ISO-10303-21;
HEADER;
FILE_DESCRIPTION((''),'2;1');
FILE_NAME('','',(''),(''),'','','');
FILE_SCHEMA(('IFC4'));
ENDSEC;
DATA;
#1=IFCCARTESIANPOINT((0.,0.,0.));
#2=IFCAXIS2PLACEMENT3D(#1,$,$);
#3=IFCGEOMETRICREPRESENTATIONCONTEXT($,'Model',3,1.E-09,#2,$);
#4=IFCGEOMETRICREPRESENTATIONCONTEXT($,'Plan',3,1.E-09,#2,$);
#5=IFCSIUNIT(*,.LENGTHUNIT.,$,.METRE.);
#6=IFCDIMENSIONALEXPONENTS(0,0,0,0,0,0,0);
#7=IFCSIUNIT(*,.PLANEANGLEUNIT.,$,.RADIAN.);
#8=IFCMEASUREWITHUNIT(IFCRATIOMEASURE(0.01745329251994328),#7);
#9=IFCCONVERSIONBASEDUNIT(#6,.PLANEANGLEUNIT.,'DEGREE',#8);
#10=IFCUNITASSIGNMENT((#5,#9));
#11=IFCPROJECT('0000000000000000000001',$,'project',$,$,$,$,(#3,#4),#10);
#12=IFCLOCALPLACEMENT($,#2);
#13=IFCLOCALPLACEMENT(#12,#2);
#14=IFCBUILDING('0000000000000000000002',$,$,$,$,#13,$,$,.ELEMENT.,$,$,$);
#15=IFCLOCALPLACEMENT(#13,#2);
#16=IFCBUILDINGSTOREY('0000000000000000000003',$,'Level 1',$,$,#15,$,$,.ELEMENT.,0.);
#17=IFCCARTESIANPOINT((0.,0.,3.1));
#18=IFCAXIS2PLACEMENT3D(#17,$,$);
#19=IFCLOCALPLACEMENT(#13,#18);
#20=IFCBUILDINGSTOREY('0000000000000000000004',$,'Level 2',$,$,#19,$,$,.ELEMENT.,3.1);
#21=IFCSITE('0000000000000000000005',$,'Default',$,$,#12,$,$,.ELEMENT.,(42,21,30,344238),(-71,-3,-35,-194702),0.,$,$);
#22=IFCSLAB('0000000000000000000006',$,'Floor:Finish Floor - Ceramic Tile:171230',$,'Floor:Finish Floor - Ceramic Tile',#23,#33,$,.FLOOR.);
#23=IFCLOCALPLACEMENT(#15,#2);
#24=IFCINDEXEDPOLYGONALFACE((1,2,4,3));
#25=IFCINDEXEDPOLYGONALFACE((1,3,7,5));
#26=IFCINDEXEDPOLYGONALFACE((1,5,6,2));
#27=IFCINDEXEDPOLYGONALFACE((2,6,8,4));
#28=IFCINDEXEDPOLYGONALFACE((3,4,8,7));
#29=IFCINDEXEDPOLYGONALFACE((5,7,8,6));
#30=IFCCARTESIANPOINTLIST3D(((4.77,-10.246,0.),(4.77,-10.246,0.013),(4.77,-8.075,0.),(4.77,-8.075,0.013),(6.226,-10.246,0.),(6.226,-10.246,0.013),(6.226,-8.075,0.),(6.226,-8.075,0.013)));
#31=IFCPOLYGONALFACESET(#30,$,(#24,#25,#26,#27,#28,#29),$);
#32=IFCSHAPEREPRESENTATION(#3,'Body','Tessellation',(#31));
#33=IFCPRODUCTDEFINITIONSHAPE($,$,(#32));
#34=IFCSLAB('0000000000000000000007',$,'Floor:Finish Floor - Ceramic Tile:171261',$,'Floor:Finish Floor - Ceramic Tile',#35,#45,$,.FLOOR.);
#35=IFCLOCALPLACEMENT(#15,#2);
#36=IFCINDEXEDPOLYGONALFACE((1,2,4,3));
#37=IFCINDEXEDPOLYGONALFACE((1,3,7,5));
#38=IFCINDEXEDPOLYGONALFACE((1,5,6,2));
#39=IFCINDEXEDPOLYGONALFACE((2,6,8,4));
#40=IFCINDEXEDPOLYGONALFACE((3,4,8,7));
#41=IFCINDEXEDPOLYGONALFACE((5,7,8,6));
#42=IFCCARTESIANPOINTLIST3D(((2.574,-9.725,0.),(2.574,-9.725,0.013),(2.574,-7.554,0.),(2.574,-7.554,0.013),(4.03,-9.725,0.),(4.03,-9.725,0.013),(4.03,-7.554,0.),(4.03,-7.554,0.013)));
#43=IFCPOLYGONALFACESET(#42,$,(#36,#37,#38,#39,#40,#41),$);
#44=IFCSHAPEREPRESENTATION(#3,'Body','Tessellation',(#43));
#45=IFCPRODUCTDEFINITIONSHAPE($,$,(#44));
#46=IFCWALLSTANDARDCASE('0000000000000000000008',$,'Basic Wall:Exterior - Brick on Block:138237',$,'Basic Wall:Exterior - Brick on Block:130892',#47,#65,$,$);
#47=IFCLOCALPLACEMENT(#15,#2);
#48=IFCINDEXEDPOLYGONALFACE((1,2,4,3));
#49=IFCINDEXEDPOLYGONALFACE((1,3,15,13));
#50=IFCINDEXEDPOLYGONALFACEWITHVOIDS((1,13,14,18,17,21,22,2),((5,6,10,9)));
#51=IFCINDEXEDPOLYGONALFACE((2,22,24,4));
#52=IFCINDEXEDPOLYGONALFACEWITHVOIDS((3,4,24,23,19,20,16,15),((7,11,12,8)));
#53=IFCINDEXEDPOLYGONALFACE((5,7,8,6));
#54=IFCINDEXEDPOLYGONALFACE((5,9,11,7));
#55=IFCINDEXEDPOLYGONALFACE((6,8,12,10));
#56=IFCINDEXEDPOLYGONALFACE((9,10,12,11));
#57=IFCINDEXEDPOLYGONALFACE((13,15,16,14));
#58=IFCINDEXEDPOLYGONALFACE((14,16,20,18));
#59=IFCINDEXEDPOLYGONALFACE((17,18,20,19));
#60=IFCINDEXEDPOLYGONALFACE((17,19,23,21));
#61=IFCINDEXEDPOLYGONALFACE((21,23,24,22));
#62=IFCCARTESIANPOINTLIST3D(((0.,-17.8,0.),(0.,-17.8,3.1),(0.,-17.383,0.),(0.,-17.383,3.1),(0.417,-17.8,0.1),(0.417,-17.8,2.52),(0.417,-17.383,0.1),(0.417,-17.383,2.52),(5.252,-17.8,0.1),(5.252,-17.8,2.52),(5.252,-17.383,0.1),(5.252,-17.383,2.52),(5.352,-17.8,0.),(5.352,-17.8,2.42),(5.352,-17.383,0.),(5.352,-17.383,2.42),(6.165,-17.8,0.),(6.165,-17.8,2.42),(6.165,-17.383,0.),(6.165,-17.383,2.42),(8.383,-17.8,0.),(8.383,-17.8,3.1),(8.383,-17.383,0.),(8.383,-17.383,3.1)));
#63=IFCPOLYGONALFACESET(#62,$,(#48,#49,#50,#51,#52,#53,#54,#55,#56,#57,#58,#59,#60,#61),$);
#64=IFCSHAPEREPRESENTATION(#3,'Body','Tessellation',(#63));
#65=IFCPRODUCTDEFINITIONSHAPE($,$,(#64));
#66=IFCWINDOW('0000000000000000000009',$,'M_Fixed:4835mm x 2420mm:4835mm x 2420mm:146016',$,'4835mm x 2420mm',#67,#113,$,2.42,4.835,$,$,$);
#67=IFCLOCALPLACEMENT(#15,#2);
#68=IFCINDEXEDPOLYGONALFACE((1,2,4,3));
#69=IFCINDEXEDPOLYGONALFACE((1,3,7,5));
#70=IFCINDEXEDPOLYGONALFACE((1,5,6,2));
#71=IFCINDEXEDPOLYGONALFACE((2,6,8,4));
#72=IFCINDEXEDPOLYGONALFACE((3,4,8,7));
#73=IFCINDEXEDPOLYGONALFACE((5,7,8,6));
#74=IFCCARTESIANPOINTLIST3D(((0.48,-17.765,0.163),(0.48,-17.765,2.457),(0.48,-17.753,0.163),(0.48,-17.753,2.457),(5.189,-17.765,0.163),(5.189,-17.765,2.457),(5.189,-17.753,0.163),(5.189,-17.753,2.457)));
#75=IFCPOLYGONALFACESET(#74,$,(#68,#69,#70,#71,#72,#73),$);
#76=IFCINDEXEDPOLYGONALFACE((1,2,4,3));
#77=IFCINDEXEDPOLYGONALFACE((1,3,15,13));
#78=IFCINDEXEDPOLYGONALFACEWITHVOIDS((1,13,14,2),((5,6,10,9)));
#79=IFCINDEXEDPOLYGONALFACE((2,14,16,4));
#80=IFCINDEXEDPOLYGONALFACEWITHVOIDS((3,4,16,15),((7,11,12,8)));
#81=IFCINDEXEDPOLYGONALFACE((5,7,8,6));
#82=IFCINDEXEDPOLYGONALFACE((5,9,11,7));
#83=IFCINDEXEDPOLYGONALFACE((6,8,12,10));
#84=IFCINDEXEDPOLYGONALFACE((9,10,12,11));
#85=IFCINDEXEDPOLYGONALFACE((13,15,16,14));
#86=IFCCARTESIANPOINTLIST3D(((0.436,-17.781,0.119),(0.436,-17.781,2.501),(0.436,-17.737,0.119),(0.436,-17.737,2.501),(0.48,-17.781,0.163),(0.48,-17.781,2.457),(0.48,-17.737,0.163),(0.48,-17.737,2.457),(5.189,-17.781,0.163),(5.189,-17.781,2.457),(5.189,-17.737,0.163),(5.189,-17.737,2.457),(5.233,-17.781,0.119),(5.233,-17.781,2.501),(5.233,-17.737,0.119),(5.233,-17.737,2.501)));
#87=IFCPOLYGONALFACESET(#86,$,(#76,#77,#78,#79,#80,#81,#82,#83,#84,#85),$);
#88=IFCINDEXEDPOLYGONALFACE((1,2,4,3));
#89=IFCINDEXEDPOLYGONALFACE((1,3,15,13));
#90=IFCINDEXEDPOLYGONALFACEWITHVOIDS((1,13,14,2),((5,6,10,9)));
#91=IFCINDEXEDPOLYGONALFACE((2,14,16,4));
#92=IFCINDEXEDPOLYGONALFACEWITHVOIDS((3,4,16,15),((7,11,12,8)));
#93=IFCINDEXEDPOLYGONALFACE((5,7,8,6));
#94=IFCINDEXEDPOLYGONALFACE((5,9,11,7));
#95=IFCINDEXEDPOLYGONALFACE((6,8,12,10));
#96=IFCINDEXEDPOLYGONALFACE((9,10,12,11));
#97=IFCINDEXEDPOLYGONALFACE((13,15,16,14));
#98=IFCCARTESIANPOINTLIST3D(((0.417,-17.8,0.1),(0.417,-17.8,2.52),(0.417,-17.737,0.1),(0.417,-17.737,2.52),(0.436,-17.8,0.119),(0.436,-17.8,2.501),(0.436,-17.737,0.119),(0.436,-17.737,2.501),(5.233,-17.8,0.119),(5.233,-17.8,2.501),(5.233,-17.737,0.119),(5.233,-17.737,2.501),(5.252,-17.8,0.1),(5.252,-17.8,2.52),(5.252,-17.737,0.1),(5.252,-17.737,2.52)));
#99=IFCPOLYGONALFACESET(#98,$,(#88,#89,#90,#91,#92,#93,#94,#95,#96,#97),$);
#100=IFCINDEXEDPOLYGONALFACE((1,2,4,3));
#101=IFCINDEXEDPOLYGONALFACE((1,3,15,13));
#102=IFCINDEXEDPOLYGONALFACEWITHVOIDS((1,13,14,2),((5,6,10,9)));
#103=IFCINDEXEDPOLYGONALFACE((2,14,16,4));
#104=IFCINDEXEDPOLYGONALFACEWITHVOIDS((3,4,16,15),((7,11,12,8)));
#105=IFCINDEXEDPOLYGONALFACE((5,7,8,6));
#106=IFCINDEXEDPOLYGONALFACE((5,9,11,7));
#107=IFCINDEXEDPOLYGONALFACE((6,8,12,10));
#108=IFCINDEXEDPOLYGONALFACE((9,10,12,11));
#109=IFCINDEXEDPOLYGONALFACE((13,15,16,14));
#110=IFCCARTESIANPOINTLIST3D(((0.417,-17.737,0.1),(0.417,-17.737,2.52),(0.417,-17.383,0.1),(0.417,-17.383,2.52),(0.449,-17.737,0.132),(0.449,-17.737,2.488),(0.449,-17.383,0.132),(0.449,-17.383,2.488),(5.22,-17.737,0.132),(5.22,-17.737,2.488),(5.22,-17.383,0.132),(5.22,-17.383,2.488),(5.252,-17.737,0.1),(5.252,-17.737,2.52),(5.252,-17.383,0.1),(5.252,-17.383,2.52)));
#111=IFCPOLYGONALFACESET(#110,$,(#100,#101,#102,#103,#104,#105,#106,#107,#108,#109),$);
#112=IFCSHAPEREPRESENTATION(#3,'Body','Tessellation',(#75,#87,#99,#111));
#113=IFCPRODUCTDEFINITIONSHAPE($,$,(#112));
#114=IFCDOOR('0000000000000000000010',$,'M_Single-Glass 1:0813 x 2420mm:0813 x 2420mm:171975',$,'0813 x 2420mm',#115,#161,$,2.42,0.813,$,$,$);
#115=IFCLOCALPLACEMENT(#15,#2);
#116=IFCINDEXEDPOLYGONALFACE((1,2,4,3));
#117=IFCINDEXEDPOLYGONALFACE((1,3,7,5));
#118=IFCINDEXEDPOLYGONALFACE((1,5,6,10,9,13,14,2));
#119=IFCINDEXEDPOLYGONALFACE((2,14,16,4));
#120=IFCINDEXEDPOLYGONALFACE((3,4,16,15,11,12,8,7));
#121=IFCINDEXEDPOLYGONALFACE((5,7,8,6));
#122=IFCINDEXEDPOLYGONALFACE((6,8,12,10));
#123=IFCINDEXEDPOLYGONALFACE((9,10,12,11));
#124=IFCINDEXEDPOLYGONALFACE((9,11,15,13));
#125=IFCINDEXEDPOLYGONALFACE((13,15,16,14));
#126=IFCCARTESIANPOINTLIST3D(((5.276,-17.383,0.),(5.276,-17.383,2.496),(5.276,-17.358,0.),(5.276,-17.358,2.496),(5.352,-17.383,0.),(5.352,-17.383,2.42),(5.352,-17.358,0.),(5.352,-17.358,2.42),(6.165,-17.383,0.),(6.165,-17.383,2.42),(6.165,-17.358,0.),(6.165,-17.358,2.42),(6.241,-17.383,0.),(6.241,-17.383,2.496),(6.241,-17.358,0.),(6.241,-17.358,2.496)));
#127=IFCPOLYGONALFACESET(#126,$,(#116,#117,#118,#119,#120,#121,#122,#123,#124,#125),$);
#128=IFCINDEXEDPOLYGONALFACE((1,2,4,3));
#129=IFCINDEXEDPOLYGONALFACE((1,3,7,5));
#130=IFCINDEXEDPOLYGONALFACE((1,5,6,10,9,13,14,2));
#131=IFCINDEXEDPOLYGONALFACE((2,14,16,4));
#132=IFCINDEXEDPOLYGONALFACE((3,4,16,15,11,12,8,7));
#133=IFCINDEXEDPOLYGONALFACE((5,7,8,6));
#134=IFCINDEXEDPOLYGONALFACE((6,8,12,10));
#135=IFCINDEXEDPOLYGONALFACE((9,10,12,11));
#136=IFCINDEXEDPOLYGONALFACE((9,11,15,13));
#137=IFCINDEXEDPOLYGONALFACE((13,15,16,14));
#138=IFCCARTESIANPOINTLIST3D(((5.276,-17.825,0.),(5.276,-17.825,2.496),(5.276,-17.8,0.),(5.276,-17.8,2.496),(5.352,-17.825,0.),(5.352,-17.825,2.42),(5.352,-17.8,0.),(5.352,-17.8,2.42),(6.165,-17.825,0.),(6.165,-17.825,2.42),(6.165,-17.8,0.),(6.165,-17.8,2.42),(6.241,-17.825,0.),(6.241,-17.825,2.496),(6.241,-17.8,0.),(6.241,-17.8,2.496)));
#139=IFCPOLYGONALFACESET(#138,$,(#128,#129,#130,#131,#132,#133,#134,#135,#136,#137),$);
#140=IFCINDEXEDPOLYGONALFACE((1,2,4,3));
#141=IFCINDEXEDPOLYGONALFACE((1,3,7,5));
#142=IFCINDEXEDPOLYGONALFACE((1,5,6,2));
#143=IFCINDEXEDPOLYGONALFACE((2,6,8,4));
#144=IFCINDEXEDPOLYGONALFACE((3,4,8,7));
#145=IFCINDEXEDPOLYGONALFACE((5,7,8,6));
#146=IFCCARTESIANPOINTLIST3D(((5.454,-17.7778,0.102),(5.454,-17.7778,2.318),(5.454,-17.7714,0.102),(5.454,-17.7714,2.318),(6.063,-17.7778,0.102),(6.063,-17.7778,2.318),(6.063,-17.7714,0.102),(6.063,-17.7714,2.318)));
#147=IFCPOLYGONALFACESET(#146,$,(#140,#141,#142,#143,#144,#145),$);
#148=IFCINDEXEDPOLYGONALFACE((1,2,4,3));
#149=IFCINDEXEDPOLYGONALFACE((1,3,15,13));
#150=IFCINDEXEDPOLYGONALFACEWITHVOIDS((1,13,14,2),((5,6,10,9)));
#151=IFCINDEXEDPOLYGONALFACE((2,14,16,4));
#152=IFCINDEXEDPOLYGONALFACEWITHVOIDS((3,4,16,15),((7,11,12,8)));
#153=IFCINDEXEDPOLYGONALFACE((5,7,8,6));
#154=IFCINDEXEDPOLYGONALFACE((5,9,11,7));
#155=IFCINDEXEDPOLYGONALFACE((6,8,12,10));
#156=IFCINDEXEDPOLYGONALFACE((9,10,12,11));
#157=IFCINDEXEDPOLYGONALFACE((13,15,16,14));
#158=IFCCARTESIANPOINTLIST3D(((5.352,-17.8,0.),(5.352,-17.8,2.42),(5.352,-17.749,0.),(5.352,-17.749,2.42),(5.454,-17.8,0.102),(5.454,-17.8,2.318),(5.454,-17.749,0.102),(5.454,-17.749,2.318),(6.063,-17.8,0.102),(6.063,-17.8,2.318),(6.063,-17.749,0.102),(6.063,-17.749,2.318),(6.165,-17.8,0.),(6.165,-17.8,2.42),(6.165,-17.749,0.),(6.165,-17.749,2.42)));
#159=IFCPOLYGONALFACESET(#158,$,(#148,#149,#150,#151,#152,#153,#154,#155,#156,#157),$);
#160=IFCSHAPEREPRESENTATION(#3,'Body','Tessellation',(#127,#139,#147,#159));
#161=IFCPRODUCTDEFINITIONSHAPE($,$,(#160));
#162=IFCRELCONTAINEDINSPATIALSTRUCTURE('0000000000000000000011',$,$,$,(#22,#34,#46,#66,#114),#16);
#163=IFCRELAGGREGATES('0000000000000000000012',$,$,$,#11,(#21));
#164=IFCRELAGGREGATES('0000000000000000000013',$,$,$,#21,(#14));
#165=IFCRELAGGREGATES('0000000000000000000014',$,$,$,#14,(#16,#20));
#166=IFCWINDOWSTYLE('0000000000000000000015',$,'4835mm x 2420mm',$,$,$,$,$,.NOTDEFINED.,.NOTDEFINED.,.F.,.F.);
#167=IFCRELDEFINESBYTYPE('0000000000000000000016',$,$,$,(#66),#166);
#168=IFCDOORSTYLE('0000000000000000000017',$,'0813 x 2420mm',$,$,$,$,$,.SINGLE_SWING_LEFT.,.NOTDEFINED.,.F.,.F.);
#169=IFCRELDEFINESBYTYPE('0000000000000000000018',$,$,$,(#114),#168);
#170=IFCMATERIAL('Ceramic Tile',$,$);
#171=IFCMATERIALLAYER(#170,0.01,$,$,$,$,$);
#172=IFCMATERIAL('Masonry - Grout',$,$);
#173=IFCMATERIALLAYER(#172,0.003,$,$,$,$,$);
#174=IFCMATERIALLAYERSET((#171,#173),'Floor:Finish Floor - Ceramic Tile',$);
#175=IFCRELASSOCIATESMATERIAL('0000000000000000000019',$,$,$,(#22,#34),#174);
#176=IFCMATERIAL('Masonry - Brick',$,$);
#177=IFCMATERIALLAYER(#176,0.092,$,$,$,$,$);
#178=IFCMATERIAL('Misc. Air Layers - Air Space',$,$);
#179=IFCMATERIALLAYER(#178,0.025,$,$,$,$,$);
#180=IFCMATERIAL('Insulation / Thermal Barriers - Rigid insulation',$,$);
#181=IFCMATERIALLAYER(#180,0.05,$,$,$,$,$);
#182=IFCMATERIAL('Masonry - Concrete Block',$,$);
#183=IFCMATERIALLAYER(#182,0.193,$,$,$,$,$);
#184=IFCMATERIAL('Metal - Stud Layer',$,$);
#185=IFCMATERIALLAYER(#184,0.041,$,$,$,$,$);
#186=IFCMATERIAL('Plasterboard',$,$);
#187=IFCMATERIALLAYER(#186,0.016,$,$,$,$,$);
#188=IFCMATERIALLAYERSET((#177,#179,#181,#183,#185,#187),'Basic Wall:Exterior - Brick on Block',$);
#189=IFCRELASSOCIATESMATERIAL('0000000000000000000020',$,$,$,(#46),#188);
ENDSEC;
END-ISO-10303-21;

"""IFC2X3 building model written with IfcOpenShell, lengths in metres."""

from ifc_helpers import new_model, entity, si_unit, converted_unit, frame, frame_2d, origin, origin_2d_with_axis, place, context, project, spatial, polyline, rectangle, outline, extrude, source, transform, mapped, material, layer, layer_set, layer_usage, type_object, type_shapes, element, fill, save


model = new_model("IFC2X3")

# Units and contexts
model_context = context("Model", 3, precision=1e-09, world=origin())
plan_context = context("Plan", 3, precision=1e-09, world=origin())
ifc_project = project(units=[si_unit("LENGTHUNIT", "METRE"), converted_unit("PLANEANGLEUNIT", "DEGREE", entity("IfcRatioMeasure", 0.01745329251994328), si_unit("PLANEANGLEUNIT", "RADIAN"), dimensions=[0, 0, 0, 0, 0, 0, 0])], contexts=[model_context, plan_context])

# Site, building, storey
site_placement = place(None, origin())
site = spatial("IfcSite", under=ifc_project, at=site_placement, Name="Default", CompositionType="ELEMENT", RefLatitude=(42, 21, 30, 344238), RefLongitude=(-71, -3, -35, -194702), RefElevation=0.0)
building_placement = place(site_placement, origin())
building = spatial("IfcBuilding", under=site, at=building_placement, CompositionType="ELEMENT")
storey_1_placement = place(building_placement, origin())
storey_1 = spatial("IfcBuildingStorey", under=building, at=storey_1_placement, Name="Level 1", CompositionType="ELEMENT", Elevation=0.0)

# Slabs
ifc_material_1 = material(Name="Ceramic Tile")
ifc_layer_1 = layer(ifc_material_1, 0.01)
ifc_material_2 = material(Name="Masonry - Grout")
ifc_layer_2 = layer(ifc_material_2, 0.003)
ifc_layer_set_1 = layer_set([ifc_layer_1, ifc_layer_2], Name="Floor:Finish Floor - Ceramic Tile")
ifc_layer_usage_1 = layer_usage(ifc_layer_set_1, "AXIS3", "POSITIVE", 0.0)
slab_1_placement = place(storey_1_placement, frame((4.77, -10.246, 0.0)))
element("IfcSlab", 1, at=slab_1_placement, inside=storey_1, material=ifc_layer_usage_1, Name="Floor:Finish Floor - Ceramic Tile:171230", ObjectType="Floor:Finish Floor - Ceramic Tile", PredefinedType="FLOOR", context=model_context, shape_type="SweptSolid", body=[
    extrude(rectangle(XDim=1.456, YDim=2.171, at=frame_2d((0.0, 0.0), x_axis=(-1.0, 0.0))), frame((0.728, 1.0855, 0.013), z_axis=(0.0, 0.0, -1.0), x_axis=(-1.0, 0.0, 0.0)), (0.0, 0.0, 1.0), 0.013),
])
ifc_layer_usage_2 = layer_usage(ifc_layer_set_1, "AXIS3", "POSITIVE", 0.0)
slab_2_placement = place(storey_1_placement, frame((2.574, -9.725, 0.0)))
element("IfcSlab", 2, at=slab_2_placement, inside=storey_1, material=ifc_layer_usage_2, Name="Floor:Finish Floor - Ceramic Tile:171261", ObjectType="Floor:Finish Floor - Ceramic Tile", PredefinedType="FLOOR", context=model_context, shape_type="SweptSolid", body=[
    extrude(rectangle(XDim=2.171, YDim=1.456, at=frame_2d((0.0, 0.0), x_axis=(0.0, -1.0))), frame((0.728, 1.0855, 0.013), z_axis=(0.0, 0.0, -1.0), x_axis=(-1.0, 0.0, 0.0)), (0.0, 0.0, 1.0), 0.013),
])

# Wall, openings, window, door
ifc_material_3 = material(Name="Masonry - Brick")
ifc_layer_3 = layer(ifc_material_3, 0.092)
ifc_material_4 = material(Name="Misc. Air Layers - Air Space")
ifc_layer_4 = layer(ifc_material_4, 0.025)
ifc_material_5 = material(Name="Insulation / Thermal Barriers - Rigid insulation")
ifc_layer_5 = layer(ifc_material_5, 0.05)
ifc_material_6 = material(Name="Masonry - Concrete Block")
ifc_layer_6 = layer(ifc_material_6, 0.193)
ifc_material_7 = material(Name="Metal - Stud Layer")
ifc_layer_7 = layer(ifc_material_7, 0.041)
ifc_material_8 = material(Name="Plasterboard")
ifc_layer_8 = layer(ifc_material_8, 0.016)
ifc_layer_set_2 = layer_set([ifc_layer_3, ifc_layer_4, ifc_layer_5, ifc_layer_6, ifc_layer_7, ifc_layer_8], Name="Basic Wall:Exterior - Brick on Block")
ifc_layer_usage_3 = layer_usage(ifc_layer_set_2, "AXIS2", "NEGATIVE", 0.2085)
wall_1_placement = place(storey_1_placement, frame((8.383, -17.5915, 0.0), z_axis=(0.0, 0.0, 1.0), x_axis=(-1.0, 0.0, 0.0)))
wall_1 = element("IfcWallStandardCase", 3, at=wall_1_placement, inside=storey_1, material=ifc_layer_usage_3, Name="Basic Wall:Exterior - Brick on Block:138237", ObjectType="Basic Wall:Exterior - Brick on Block:130892", context=model_context, shape_type="SweptSolid", body=[
    extrude(rectangle(XDim=8.383, YDim=0.417, at=frame_2d((4.1915, 0.0), x_axis=(-1.0, 0.0))), origin(), (0.0, 0.0, 1.0), 3.1),
])
opening_1_placement = place(wall_1_placement, frame((3.131, -0.2085, 0.1)))
opening_1 = element("IfcOpeningElement", 4, at=opening_1_placement, cuts=wall_1, ObjectType="Opening", context=model_context, shape_type="SweptSolid", body=[
    extrude(rectangle(XDim=2.42, YDim=4.835, at=frame_2d((1.21, 2.4175), x_axis=(1.0, 0.0))), frame((0.0, 0.0, 0.0), z_axis=(0.0, 1.0, 0.0), x_axis=(0.0, 0.0, 1.0)), (0.0, 0.0, 1.0), 0.417),
])
opening_2_placement = place(wall_1_placement, frame((2.218, -0.2085, 0.0)))
opening_2 = element("IfcOpeningElement", 5, at=opening_2_placement, cuts=wall_1, ObjectType="Opening", context=model_context, shape_type="SweptSolid", body=[
    extrude(rectangle(XDim=0.813, YDim=2.42, at=frame_2d((1.21, 0.4065), x_axis=(0.0, -1.0))), frame((0.0, 0.0, 0.0), z_axis=(0.0, 1.0, 0.0), x_axis=(0.0, 0.0, 1.0)), (0.0, 0.0, 1.0), 0.417),
])
window_style_1 = type_object("IfcWindowStyle", Name="4835mm x 2420mm", ConstructionType="NOTDEFINED", OperationType="NOTDEFINED", ParameterTakesPrecedence=False, Sizeable=False)
shared_shape_1 = source(origin(), model_context, "Body", "SweptSolid", [
    extrude(rectangle(XDim=0.012, YDim=4.709, at=origin_2d_with_axis()), frame((2.4175, 0.376, 0.063), z_axis=(0.0, 0.0, 1.0), x_axis=(0.0, -1.0, 0.0)), (0.0, 0.0, 1.0), 2.294),
    extrude(outline(polyline([(-2.3985, -1.191), (2.3985, -1.191), (2.3985, 1.191), (-2.3985, 1.191), (-2.3985, -1.191)]), holes=[polyline([(-2.3545, -1.147), (-2.3545, 1.147), (2.3545, 1.147), (2.3545, -1.147), (-2.3545, -1.147)])]), frame((2.4175, 0.354, 1.21), z_axis=(0.0, 1.0, 0.0), x_axis=(1.0, 0.0, 0.0)), (0.0, 0.0, 1.0), 0.044),
    extrude(outline(polyline([(-2.4175, -1.21), (2.4175, -1.21), (2.4175, 1.21), (-2.4175, 1.21), (-2.4175, -1.21)]), holes=[polyline([(-2.3985, -1.191), (-2.3985, 1.191), (2.3985, 1.191), (2.3985, -1.191), (-2.3985, -1.191)])]), frame((2.4175, 0.354, 1.21), z_axis=(0.0, 1.0, 0.0), x_axis=(1.0, 0.0, 0.0)), (0.0, 0.0, 1.0), 0.063),
    extrude(outline(polyline([(-2.4175, -1.21), (2.4175, -1.21), (2.4175, 1.21), (-2.4175, 1.21), (-2.4175, -1.21)]), holes=[polyline([(-2.3855, -1.178), (-2.3855, 1.178), (2.3855, 1.178), (2.3855, -1.178), (-2.3855, -1.178)])]), frame((2.4175, 0.0, 1.21), z_axis=(0.0, 1.0, 0.0), x_axis=(1.0, 0.0, 0.0)), (0.0, 0.0, 1.0), 0.354),
])
type_shapes(window_style_1, [shared_shape_1])
window_1_placement = place(opening_1_placement, origin())
window_1 = element("IfcWindow", 6, at=window_1_placement, inside=storey_1, type_object=window_style_1, Name="M_Fixed:4835mm x 2420mm:4835mm x 2420mm:146016", ObjectType="4835mm x 2420mm", OverallHeight=2.42, OverallWidth=4.835, context=model_context, shape_type="MappedRepresentation", body=[
    mapped(shared_shape_1, transform((0.0, 0.0, 0.0), scale=1.0)),
])
fill(opening_1, window_1)
door_style_1 = type_object("IfcDoorStyle", Name="0813 x 2420mm", ConstructionType="NOTDEFINED", OperationType="SINGLE_SWING_LEFT", ParameterTakesPrecedence=False, Sizeable=False)
shared_shape_2 = source(origin(), model_context, "Body", "SweptSolid", [
    extrude(outline(polyline([(-0.4065, -1.191), (-0.4065, 1.229), (-0.4825, 1.229), (-0.4825, -1.267), (0.4825, -1.267), (0.4825, 1.229), (0.4065, 1.229), (0.4065, -1.191), (-0.4065, -1.191)])), frame((0.4065, 0.0, 1.229), z_axis=(0.0, 1.0, 0.0), x_axis=(1.0, 0.0, 0.0)), (0.0, 0.0, -1.0), 0.025),
    extrude(outline(polyline([(-0.4065, -1.191), (-0.4065, 1.229), (-0.4825, 1.229), (-0.4825, -1.267), (0.4825, -1.267), (0.4825, 1.229), (0.4065, 1.229), (0.4065, -1.191), (-0.4065, -1.191)])), frame((0.4065, 0.442, 1.229), z_axis=(0.0, 1.0, 0.0), x_axis=(1.0, 0.0, 0.0)), (0.0, 0.0, -1.0), 0.025),
    extrude(rectangle(XDim=0.609, YDim=0.0064, at=origin_2d_with_axis()), frame((0.4065, 0.3916, 0.102)), (0.0, 0.0, 1.0), 2.216),
    extrude(outline(polyline([(-1.21, -0.4065), (1.21, -0.4065), (1.21, 0.4065), (-1.21, 0.4065), (-1.21, -0.4065)]), holes=[polyline([(-1.108, 0.3045), (1.108, 0.3045), (1.108, -0.3045), (-1.108, -0.3045), (-1.108, 0.3045)])]), frame((0.4065, 0.417, 1.21), z_axis=(0.0, -1.0, 0.0), x_axis=(0.0, 0.0, -1.0)), (0.0, 0.0, 1.0), 0.051),
])
type_shapes(door_style_1, [shared_shape_2])
door_1_placement = place(opening_2_placement, origin())
door_1 = element("IfcDoor", 7, at=door_1_placement, inside=storey_1, type_object=door_style_1, Name="M_Single-Glass 1:0813 x 2420mm:0813 x 2420mm:171975", ObjectType="0813 x 2420mm", OverallHeight=2.42, OverallWidth=0.813, context=model_context, shape_type="MappedRepresentation", body=[
    mapped(shared_shape_2, transform((0.0, 0.0, 0.0), scale=1.0)),
])
fill(opening_2, door_1)

# Shared definitions
storey_2_placement = place(building_placement, frame((0.0, 0.0, 3.1)))
storey_2 = spatial("IfcBuildingStorey", under=building, at=storey_2_placement, Name="Level 2", CompositionType="ELEMENT", Elevation=3.1)

save(model, "model.ifc")
